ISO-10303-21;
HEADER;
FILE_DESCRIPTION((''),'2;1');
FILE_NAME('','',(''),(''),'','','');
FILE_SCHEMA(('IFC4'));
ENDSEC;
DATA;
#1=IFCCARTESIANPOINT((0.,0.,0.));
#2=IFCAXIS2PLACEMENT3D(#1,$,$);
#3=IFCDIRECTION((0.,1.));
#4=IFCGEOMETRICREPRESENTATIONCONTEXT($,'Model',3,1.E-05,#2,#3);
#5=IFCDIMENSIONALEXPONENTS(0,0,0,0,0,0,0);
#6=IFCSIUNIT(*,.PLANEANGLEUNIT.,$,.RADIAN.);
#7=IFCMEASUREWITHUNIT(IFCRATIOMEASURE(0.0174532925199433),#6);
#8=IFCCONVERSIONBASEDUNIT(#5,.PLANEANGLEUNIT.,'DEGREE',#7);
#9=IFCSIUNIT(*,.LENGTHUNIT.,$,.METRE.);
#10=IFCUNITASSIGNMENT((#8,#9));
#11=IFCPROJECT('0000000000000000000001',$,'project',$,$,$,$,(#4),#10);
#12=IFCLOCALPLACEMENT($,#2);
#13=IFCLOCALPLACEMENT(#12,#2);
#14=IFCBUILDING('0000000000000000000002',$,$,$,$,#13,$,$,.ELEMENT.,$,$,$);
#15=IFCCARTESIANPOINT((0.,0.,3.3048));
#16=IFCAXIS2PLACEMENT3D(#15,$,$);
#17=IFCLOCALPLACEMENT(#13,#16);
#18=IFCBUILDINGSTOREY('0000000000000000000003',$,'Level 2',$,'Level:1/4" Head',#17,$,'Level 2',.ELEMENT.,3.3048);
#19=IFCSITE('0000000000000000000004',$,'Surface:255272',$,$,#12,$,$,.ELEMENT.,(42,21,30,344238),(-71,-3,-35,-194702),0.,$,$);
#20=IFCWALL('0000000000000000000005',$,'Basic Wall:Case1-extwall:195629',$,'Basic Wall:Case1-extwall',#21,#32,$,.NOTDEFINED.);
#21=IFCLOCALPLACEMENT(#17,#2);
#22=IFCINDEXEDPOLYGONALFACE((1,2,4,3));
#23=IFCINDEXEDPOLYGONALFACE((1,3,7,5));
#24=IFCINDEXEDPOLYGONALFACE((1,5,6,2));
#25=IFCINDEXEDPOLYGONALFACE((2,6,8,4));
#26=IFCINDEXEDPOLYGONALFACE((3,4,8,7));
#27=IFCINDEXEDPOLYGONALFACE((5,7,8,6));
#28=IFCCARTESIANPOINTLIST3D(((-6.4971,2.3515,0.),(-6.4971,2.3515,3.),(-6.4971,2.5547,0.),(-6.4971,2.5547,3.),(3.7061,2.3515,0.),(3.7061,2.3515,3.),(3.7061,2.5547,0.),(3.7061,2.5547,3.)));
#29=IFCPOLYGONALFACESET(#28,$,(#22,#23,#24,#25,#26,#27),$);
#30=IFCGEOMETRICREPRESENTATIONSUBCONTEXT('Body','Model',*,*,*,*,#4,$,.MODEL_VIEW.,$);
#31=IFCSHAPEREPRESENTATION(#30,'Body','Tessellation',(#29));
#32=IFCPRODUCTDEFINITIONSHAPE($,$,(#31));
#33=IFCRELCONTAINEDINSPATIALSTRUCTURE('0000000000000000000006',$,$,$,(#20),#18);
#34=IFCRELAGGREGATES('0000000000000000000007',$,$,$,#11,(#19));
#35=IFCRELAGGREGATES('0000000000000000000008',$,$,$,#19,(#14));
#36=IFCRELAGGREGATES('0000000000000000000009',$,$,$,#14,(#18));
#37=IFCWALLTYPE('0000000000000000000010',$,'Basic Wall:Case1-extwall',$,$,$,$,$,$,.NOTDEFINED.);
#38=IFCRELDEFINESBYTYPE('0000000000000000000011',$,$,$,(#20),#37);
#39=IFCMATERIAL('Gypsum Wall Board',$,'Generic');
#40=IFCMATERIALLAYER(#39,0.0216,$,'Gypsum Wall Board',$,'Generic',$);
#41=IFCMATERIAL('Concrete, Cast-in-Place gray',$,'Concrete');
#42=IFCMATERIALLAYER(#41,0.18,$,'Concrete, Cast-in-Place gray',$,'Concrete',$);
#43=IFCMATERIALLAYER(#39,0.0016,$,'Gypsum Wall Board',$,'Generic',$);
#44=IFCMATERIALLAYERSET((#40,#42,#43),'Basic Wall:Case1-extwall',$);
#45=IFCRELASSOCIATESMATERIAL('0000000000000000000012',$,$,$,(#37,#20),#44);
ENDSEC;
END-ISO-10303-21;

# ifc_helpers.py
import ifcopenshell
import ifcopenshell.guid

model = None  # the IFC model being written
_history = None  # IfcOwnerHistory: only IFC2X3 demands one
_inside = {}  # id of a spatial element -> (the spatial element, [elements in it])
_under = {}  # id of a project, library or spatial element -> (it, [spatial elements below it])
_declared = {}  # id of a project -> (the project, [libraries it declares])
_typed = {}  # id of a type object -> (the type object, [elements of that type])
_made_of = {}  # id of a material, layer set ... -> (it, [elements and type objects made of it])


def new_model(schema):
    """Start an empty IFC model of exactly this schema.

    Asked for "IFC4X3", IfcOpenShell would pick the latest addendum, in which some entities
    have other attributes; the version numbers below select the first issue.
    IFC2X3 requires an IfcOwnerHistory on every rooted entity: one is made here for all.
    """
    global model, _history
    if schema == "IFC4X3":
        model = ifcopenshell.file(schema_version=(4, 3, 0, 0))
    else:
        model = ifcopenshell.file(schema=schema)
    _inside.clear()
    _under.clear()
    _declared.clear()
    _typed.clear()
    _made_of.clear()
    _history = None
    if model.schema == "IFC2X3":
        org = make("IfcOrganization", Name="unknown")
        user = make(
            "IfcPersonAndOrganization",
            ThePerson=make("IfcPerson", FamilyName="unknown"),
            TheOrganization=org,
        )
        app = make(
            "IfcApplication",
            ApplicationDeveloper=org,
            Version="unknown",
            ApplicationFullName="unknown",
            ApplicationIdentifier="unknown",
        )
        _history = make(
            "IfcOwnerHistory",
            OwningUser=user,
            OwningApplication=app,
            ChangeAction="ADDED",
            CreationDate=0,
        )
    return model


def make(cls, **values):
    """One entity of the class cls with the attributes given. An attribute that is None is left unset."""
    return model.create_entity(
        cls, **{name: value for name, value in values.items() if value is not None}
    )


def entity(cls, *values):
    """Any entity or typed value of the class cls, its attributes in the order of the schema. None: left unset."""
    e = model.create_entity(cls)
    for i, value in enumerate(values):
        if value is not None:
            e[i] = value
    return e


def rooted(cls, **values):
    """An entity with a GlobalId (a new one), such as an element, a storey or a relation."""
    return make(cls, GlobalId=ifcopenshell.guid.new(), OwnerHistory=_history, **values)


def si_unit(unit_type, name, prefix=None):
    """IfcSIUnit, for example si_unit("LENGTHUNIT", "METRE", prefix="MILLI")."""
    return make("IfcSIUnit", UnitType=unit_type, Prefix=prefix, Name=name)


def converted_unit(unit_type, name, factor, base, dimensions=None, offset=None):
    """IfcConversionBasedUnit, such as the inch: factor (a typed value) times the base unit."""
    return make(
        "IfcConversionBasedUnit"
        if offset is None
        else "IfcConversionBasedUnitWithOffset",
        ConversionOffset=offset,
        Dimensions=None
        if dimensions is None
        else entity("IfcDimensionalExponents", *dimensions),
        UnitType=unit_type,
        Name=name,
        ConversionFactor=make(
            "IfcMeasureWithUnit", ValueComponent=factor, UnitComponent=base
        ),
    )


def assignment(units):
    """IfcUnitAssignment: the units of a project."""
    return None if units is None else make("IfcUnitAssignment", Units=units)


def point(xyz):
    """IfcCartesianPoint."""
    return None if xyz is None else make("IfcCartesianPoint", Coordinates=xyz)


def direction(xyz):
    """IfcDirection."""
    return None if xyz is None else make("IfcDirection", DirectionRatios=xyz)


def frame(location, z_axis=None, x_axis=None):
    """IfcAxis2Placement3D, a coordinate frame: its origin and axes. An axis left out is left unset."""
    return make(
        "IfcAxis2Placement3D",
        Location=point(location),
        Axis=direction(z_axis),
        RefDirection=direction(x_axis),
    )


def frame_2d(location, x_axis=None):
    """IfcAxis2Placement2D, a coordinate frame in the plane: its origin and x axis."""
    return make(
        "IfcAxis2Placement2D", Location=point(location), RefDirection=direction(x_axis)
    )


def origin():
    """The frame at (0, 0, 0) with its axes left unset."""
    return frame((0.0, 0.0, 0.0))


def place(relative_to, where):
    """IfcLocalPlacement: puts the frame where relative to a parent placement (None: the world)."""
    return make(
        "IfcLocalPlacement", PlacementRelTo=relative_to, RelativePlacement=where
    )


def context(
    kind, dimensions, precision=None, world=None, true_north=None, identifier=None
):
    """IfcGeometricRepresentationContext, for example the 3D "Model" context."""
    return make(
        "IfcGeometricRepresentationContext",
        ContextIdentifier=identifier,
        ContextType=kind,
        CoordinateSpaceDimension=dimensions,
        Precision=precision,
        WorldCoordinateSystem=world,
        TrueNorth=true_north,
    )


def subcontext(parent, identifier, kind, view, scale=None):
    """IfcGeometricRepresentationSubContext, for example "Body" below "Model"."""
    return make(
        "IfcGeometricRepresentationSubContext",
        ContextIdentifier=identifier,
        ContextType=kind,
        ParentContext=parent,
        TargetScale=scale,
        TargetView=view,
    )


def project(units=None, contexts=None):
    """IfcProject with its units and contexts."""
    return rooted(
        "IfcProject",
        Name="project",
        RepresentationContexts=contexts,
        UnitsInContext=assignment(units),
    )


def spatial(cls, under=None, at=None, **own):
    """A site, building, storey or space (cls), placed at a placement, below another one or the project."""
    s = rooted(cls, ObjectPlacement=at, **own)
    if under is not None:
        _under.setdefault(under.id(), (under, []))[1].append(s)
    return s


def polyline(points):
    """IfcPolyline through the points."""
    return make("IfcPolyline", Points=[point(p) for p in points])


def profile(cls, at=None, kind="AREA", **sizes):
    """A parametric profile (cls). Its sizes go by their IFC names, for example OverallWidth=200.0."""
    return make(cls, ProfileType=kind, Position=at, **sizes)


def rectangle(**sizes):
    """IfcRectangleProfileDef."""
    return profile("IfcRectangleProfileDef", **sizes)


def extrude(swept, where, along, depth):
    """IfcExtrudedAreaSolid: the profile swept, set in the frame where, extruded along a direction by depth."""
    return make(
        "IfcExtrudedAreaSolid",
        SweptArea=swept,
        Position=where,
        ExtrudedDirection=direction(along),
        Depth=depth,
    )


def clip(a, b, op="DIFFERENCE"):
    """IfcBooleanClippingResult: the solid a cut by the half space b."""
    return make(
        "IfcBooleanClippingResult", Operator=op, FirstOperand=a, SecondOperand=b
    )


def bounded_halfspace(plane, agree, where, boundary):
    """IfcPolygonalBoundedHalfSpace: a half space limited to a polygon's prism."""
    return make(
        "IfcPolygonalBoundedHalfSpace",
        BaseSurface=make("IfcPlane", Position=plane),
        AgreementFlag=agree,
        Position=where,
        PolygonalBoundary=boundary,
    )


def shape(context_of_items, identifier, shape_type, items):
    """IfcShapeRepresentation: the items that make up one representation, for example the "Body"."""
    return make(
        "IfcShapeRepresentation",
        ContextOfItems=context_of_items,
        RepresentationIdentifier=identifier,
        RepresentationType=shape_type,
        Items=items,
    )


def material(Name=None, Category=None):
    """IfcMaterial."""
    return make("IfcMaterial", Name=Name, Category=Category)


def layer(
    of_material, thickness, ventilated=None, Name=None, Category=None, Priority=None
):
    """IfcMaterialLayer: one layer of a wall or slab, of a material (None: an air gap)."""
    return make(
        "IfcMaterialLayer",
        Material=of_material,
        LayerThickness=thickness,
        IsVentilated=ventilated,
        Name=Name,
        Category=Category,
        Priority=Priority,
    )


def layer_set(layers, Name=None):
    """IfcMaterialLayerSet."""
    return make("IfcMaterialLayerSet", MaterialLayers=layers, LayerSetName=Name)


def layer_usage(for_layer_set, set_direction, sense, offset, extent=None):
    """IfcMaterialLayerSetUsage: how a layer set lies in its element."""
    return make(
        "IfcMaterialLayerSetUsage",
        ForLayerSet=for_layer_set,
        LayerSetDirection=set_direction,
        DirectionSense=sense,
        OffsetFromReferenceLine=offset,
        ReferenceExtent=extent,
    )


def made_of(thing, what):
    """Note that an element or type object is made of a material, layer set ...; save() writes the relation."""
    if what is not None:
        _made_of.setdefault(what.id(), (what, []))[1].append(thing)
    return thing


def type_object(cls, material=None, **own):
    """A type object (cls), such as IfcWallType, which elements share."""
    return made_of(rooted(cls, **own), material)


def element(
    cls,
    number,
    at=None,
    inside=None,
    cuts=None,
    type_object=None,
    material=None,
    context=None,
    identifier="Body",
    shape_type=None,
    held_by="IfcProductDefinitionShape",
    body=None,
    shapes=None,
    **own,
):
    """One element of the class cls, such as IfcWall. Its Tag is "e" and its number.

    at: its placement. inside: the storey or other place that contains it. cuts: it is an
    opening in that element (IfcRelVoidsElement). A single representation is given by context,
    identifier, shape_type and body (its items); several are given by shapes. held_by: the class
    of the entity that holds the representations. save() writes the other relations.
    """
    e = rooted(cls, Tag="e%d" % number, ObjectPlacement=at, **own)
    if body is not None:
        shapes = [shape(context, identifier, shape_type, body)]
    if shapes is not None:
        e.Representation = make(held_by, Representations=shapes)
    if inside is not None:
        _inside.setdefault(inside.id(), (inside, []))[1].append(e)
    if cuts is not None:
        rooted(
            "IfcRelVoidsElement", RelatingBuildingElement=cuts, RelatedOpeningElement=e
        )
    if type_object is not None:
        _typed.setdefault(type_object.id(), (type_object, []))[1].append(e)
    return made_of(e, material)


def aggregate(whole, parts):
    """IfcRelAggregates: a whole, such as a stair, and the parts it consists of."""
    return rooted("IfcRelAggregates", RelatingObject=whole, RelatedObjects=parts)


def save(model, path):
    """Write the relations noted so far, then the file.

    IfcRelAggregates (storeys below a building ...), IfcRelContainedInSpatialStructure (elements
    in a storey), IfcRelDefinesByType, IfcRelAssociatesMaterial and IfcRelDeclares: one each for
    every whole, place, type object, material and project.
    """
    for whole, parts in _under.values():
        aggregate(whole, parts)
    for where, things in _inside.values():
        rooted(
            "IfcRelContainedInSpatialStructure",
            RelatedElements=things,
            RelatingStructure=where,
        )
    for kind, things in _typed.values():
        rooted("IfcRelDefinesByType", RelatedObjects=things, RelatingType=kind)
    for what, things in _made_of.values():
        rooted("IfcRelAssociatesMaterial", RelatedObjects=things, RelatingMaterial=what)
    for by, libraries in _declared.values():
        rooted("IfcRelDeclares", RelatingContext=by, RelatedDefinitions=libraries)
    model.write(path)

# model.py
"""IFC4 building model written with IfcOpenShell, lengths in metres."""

from ifc_helpers import new_model, entity, si_unit, converted_unit, direction, frame, frame_2d, origin, place, context, subcontext, project, spatial, polyline, rectangle, extrude, clip, bounded_halfspace, material, layer, layer_set, layer_usage, type_object, element, save


model = new_model("IFC4")

# Units and contexts
model_context = context("Model", 3, precision=1e-05, world=origin(), true_north=direction((0.0, 1.0)))
body_context = subcontext(model_context, "Body", "Model", "MODEL_VIEW")
ifc_project = project(units=[converted_unit("PLANEANGLEUNIT", "DEGREE", entity("IfcRatioMeasure", 0.0174532925199433), si_unit("PLANEANGLEUNIT", "RADIAN"), dimensions=[0, 0, 0, 0, 0, 0, 0]), si_unit("LENGTHUNIT", "METRE")], contexts=[model_context])

# Site, building, storey
site_placement = place(None, origin())
site = spatial("IfcSite", under=ifc_project, at=site_placement, Name="Surface:255272", CompositionType="ELEMENT", RefLatitude=(42, 21, 30, 344238), RefLongitude=(-71, -3, -35, -194702), RefElevation=0.0)
building_placement = place(site_placement, origin())
building = spatial("IfcBuilding", under=site, at=building_placement, CompositionType="ELEMENT")
storey_placement = place(building_placement, frame((0.0, 0.0, 3.3048)))
storey = spatial("IfcBuildingStorey", under=building, at=storey_placement, Name="Level 2", ObjectType="Level:1/4\" Head", LongName="Level 2", CompositionType="ELEMENT", Elevation=3.3048)

# Wall
ifc_material_1 = material(Name="Gypsum Wall Board", Category="Generic")
ifc_layer_1 = layer(ifc_material_1, 0.0216, Name="Gypsum Wall Board", Category="Generic")
ifc_material_2 = material(Name="Concrete, Cast-in-Place gray", Category="Concrete")
ifc_layer_2 = layer(ifc_material_2, 0.18, Name="Concrete, Cast-in-Place gray", Category="Concrete")
ifc_layer_3 = layer(ifc_material_1, 0.0016, Name="Gypsum Wall Board", Category="Generic")
ifc_layer_set_1 = layer_set([ifc_layer_1, ifc_layer_2, ifc_layer_3], Name="Basic Wall:Case1-extwall")
ifc_layer_usage_1 = layer_usage(ifc_layer_set_1, "AXIS2", "NEGATIVE", 0.1016)
wall_type = type_object("IfcWallType", Name="Basic Wall:Case1-extwall", PredefinedType="NOTDEFINED", material=ifc_layer_set_1)
wall_placement = place(storey_placement, frame((-6.4971, 2.4531, 0.0)))
element("IfcWall", 1, at=wall_placement, inside=storey, type_object=wall_type, material=ifc_layer_usage_1, Name="Basic Wall:Case1-extwall:195629", ObjectType="Basic Wall:Case1-extwall", PredefinedType="NOTDEFINED", context=body_context, shape_type="Clipping", body=[
    clip(extrude(rectangle(XDim=10.2032, YDim=0.2032, at=frame_2d((5.1016, 0.0), x_axis=(-1.0, 0.0))), origin(), (0.0, 0.0, 1.0), 3.0), bounded_halfspace(frame((0.0, -0.1016, 3.0)), False, frame((0.0, -0.1016, 3.0)), polyline([(0.0, 0.0), (5.646, 0.0), (5.7984, 0.0), (10.0, 0.0), (10.2032, 0.0), (10.2032, 0.2032), (0.0, 0.2032), (0.0, 0.0)]))),
])

save(model, "model.ifc")
